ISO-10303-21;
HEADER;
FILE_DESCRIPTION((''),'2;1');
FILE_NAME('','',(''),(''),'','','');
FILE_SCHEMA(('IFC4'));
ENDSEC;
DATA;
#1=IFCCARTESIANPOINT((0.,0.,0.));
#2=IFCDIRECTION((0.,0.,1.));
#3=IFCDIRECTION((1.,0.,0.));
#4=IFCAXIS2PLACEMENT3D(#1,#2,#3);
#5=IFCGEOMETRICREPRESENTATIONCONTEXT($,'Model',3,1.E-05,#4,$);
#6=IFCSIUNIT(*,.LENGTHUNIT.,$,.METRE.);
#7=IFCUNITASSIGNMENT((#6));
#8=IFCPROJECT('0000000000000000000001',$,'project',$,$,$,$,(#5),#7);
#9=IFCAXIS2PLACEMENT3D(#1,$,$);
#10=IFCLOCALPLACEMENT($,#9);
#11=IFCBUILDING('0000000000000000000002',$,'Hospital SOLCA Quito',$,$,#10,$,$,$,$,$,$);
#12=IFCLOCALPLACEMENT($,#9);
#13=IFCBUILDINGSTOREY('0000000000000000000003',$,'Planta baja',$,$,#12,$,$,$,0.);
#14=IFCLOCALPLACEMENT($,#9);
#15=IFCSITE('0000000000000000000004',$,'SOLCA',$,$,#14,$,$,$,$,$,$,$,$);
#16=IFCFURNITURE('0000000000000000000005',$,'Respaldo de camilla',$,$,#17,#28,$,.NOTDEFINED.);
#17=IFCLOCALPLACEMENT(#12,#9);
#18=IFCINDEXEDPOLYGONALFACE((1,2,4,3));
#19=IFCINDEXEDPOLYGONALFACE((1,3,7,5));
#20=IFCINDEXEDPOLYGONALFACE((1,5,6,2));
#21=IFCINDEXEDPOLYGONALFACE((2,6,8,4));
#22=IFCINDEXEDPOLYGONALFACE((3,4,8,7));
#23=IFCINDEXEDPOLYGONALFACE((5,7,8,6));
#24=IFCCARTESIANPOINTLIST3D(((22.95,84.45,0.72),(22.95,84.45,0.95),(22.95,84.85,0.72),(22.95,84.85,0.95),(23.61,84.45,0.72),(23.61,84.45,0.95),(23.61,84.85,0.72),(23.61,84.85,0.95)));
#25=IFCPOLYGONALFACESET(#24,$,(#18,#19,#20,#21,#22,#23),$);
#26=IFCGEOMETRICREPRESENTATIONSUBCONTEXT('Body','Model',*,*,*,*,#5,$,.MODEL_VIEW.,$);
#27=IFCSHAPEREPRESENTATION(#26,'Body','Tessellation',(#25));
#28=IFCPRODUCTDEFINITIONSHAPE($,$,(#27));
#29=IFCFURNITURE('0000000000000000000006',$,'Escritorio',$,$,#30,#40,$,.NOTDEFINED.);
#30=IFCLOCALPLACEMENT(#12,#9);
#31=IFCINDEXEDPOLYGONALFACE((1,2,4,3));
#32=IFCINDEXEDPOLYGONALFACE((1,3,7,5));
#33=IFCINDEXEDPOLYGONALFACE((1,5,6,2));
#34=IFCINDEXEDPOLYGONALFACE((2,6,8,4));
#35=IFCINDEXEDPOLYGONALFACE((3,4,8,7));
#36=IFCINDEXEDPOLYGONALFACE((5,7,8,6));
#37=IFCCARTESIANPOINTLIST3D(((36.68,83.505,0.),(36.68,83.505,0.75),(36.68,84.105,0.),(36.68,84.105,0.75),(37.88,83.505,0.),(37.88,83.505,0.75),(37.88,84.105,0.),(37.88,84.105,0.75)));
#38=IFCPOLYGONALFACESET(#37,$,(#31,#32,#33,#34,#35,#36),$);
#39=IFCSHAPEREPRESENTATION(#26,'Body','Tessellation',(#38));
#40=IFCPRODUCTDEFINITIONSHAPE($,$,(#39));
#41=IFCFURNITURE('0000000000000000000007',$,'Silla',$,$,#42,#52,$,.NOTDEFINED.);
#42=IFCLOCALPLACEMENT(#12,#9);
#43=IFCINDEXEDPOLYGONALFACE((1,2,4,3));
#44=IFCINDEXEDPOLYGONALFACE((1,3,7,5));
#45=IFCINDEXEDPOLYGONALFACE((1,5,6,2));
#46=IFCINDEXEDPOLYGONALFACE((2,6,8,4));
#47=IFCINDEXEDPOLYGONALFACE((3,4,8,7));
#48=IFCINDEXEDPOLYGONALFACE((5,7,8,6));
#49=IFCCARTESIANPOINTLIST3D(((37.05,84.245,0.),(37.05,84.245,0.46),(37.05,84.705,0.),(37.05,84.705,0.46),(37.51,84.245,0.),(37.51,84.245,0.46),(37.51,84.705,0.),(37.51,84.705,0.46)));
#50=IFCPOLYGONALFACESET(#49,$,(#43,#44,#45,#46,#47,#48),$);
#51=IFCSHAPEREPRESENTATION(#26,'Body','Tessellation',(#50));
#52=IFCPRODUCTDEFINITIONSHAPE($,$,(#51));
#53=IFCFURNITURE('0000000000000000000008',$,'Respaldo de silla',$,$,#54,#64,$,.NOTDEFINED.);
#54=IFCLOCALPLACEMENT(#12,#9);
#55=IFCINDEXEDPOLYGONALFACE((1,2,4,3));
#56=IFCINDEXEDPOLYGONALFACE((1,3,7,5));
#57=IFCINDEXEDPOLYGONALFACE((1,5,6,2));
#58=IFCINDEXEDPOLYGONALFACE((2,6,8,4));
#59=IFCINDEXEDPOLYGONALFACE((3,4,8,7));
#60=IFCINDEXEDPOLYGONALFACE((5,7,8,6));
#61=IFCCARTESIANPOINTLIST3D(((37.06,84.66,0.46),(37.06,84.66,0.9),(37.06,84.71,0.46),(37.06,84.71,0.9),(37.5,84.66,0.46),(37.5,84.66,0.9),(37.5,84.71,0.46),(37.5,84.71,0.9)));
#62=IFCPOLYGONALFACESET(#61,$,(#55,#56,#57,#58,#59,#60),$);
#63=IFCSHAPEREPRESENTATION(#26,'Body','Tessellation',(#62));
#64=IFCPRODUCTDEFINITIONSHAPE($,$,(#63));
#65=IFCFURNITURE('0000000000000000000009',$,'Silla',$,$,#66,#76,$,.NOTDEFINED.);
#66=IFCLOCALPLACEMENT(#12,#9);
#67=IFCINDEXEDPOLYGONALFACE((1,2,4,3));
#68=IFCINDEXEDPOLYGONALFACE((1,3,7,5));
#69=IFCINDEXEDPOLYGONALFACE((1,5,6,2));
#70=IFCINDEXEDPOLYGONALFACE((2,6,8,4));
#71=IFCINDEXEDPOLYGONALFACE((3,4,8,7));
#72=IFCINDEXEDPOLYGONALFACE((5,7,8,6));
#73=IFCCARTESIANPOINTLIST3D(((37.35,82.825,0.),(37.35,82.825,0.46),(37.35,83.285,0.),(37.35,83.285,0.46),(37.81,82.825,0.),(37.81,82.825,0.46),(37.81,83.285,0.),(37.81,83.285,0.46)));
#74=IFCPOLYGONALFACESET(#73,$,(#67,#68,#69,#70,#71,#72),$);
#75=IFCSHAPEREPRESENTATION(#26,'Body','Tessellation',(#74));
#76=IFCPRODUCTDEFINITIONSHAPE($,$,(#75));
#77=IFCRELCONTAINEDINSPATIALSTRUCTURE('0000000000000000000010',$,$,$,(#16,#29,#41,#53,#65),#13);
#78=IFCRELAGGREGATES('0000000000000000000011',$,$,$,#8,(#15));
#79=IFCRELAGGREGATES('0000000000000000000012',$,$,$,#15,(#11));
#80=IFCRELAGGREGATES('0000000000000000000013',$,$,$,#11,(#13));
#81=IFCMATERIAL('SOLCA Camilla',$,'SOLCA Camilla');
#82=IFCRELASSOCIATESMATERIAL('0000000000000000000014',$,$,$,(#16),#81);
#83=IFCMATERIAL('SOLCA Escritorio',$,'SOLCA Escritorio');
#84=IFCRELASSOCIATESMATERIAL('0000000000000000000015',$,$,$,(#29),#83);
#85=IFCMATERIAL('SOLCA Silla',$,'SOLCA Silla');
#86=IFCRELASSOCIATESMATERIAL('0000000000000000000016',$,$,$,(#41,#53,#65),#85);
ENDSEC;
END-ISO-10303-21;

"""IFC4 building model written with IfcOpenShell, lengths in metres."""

from ifc_helpers import new_model, si_unit, frame, origin, origin_with_axes, place, context, subcontext, project, spatial, polyline, outline, extrude, material, element, save


model = new_model("IFC4")

# Units and contexts
model_context = context("Model", 3, precision=1e-05, world=origin_with_axes())
body_context = subcontext(model_context, "Body", "Model", "MODEL_VIEW")
ifc_project = project(units=[si_unit("LENGTHUNIT", "METRE")], contexts=[model_context])

# Site, building, storey
site_placement = place(None, origin())
site = spatial("IfcSite", under=ifc_project, at=site_placement, Name="SOLCA")
building_placement = place(None, origin())
building = spatial("IfcBuilding", under=site, at=building_placement, Name="Hospital SOLCA Quito")
storey_placement = place(None, origin())
storey = spatial("IfcBuildingStorey", under=building, at=storey_placement, Name="Planta baja", Elevation=0.0)

# Furniture
ifc_material_1 = material(Name="SOLCA Escritorio", Category="SOLCA Escritorio")
ifc_material_2 = material(Name="SOLCA Silla", Category="SOLCA Silla")
ifc_material_3 = material(Name="SOLCA Camilla", Category="SOLCA Camilla")
furniture_1_placement = place(storey_placement, origin_with_axes())
element("IfcFurniture", 1, at=furniture_1_placement, inside=storey, material=ifc_material_3, Name="Respaldo de camilla", PredefinedType="NOTDEFINED", context=body_context, shape_type="SweptSolid", body=[
    extrude(outline(polyline([(23.61, 84.45), (23.61, 84.85), (22.95, 84.85), (22.95, 84.45), (23.61, 84.45)])), frame((0.0, 0.0, 0.72), z_axis=(0.0, 0.0, 1.0), x_axis=(1.0, 0.0, 0.0)), (0.0, 0.0, 1.0), 0.23),
])
furniture_2_placement = place(storey_placement, origin_with_axes())
element("IfcFurniture", 2, at=furniture_2_placement, inside=storey, material=ifc_material_1, Name="Escritorio", PredefinedType="NOTDEFINED", context=body_context, shape_type="SweptSolid", body=[
    extrude(outline(polyline([(37.88, 84.105), (36.68, 84.105), (36.68, 83.505), (37.88, 83.505), (37.88, 84.105)])), origin_with_axes(), (0.0, 0.0, 1.0), 0.75),
])
furniture_3_placement = place(storey_placement, origin_with_axes())
element("IfcFurniture", 3, at=furniture_3_placement, inside=storey, material=ifc_material_2, Name="Silla", PredefinedType="NOTDEFINED", context=body_context, shape_type="SweptSolid", body=[
    extrude(outline(polyline([(37.51, 84.705), (37.05, 84.705), (37.05, 84.245), (37.51, 84.245), (37.51, 84.705)])), origin_with_axes(), (0.0, 0.0, 1.0), 0.46),
])
furniture_4_placement = place(storey_placement, origin_with_axes())
element("IfcFurniture", 4, at=furniture_4_placement, inside=storey, material=ifc_material_2, Name="Respaldo de silla", PredefinedType="NOTDEFINED", context=body_context, shape_type="SweptSolid", body=[
    extrude(outline(polyline([(37.5, 84.71), (37.06, 84.71), (37.06, 84.66), (37.5, 84.66), (37.5, 84.71)])), frame((0.0, 0.0, 0.46), z_axis=(0.0, 0.0, 1.0), x_axis=(1.0, 0.0, 0.0)), (0.0, 0.0, 1.0), 0.44),
])
furniture_5_placement = place(storey_placement, origin_with_axes())
element("IfcFurniture", 5, at=furniture_5_placement, inside=storey, material=ifc_material_2, Name="Silla", PredefinedType="NOTDEFINED", context=body_context, shape_type="SweptSolid", body=[
    extrude(outline(polyline([(37.81, 83.285), (37.35, 83.285), (37.35, 82.825), (37.81, 82.825), (37.81, 83.285)])), origin_with_axes(), (0.0, 0.0, 1.0), 0.46),
])

save(model, "model.ifc")
